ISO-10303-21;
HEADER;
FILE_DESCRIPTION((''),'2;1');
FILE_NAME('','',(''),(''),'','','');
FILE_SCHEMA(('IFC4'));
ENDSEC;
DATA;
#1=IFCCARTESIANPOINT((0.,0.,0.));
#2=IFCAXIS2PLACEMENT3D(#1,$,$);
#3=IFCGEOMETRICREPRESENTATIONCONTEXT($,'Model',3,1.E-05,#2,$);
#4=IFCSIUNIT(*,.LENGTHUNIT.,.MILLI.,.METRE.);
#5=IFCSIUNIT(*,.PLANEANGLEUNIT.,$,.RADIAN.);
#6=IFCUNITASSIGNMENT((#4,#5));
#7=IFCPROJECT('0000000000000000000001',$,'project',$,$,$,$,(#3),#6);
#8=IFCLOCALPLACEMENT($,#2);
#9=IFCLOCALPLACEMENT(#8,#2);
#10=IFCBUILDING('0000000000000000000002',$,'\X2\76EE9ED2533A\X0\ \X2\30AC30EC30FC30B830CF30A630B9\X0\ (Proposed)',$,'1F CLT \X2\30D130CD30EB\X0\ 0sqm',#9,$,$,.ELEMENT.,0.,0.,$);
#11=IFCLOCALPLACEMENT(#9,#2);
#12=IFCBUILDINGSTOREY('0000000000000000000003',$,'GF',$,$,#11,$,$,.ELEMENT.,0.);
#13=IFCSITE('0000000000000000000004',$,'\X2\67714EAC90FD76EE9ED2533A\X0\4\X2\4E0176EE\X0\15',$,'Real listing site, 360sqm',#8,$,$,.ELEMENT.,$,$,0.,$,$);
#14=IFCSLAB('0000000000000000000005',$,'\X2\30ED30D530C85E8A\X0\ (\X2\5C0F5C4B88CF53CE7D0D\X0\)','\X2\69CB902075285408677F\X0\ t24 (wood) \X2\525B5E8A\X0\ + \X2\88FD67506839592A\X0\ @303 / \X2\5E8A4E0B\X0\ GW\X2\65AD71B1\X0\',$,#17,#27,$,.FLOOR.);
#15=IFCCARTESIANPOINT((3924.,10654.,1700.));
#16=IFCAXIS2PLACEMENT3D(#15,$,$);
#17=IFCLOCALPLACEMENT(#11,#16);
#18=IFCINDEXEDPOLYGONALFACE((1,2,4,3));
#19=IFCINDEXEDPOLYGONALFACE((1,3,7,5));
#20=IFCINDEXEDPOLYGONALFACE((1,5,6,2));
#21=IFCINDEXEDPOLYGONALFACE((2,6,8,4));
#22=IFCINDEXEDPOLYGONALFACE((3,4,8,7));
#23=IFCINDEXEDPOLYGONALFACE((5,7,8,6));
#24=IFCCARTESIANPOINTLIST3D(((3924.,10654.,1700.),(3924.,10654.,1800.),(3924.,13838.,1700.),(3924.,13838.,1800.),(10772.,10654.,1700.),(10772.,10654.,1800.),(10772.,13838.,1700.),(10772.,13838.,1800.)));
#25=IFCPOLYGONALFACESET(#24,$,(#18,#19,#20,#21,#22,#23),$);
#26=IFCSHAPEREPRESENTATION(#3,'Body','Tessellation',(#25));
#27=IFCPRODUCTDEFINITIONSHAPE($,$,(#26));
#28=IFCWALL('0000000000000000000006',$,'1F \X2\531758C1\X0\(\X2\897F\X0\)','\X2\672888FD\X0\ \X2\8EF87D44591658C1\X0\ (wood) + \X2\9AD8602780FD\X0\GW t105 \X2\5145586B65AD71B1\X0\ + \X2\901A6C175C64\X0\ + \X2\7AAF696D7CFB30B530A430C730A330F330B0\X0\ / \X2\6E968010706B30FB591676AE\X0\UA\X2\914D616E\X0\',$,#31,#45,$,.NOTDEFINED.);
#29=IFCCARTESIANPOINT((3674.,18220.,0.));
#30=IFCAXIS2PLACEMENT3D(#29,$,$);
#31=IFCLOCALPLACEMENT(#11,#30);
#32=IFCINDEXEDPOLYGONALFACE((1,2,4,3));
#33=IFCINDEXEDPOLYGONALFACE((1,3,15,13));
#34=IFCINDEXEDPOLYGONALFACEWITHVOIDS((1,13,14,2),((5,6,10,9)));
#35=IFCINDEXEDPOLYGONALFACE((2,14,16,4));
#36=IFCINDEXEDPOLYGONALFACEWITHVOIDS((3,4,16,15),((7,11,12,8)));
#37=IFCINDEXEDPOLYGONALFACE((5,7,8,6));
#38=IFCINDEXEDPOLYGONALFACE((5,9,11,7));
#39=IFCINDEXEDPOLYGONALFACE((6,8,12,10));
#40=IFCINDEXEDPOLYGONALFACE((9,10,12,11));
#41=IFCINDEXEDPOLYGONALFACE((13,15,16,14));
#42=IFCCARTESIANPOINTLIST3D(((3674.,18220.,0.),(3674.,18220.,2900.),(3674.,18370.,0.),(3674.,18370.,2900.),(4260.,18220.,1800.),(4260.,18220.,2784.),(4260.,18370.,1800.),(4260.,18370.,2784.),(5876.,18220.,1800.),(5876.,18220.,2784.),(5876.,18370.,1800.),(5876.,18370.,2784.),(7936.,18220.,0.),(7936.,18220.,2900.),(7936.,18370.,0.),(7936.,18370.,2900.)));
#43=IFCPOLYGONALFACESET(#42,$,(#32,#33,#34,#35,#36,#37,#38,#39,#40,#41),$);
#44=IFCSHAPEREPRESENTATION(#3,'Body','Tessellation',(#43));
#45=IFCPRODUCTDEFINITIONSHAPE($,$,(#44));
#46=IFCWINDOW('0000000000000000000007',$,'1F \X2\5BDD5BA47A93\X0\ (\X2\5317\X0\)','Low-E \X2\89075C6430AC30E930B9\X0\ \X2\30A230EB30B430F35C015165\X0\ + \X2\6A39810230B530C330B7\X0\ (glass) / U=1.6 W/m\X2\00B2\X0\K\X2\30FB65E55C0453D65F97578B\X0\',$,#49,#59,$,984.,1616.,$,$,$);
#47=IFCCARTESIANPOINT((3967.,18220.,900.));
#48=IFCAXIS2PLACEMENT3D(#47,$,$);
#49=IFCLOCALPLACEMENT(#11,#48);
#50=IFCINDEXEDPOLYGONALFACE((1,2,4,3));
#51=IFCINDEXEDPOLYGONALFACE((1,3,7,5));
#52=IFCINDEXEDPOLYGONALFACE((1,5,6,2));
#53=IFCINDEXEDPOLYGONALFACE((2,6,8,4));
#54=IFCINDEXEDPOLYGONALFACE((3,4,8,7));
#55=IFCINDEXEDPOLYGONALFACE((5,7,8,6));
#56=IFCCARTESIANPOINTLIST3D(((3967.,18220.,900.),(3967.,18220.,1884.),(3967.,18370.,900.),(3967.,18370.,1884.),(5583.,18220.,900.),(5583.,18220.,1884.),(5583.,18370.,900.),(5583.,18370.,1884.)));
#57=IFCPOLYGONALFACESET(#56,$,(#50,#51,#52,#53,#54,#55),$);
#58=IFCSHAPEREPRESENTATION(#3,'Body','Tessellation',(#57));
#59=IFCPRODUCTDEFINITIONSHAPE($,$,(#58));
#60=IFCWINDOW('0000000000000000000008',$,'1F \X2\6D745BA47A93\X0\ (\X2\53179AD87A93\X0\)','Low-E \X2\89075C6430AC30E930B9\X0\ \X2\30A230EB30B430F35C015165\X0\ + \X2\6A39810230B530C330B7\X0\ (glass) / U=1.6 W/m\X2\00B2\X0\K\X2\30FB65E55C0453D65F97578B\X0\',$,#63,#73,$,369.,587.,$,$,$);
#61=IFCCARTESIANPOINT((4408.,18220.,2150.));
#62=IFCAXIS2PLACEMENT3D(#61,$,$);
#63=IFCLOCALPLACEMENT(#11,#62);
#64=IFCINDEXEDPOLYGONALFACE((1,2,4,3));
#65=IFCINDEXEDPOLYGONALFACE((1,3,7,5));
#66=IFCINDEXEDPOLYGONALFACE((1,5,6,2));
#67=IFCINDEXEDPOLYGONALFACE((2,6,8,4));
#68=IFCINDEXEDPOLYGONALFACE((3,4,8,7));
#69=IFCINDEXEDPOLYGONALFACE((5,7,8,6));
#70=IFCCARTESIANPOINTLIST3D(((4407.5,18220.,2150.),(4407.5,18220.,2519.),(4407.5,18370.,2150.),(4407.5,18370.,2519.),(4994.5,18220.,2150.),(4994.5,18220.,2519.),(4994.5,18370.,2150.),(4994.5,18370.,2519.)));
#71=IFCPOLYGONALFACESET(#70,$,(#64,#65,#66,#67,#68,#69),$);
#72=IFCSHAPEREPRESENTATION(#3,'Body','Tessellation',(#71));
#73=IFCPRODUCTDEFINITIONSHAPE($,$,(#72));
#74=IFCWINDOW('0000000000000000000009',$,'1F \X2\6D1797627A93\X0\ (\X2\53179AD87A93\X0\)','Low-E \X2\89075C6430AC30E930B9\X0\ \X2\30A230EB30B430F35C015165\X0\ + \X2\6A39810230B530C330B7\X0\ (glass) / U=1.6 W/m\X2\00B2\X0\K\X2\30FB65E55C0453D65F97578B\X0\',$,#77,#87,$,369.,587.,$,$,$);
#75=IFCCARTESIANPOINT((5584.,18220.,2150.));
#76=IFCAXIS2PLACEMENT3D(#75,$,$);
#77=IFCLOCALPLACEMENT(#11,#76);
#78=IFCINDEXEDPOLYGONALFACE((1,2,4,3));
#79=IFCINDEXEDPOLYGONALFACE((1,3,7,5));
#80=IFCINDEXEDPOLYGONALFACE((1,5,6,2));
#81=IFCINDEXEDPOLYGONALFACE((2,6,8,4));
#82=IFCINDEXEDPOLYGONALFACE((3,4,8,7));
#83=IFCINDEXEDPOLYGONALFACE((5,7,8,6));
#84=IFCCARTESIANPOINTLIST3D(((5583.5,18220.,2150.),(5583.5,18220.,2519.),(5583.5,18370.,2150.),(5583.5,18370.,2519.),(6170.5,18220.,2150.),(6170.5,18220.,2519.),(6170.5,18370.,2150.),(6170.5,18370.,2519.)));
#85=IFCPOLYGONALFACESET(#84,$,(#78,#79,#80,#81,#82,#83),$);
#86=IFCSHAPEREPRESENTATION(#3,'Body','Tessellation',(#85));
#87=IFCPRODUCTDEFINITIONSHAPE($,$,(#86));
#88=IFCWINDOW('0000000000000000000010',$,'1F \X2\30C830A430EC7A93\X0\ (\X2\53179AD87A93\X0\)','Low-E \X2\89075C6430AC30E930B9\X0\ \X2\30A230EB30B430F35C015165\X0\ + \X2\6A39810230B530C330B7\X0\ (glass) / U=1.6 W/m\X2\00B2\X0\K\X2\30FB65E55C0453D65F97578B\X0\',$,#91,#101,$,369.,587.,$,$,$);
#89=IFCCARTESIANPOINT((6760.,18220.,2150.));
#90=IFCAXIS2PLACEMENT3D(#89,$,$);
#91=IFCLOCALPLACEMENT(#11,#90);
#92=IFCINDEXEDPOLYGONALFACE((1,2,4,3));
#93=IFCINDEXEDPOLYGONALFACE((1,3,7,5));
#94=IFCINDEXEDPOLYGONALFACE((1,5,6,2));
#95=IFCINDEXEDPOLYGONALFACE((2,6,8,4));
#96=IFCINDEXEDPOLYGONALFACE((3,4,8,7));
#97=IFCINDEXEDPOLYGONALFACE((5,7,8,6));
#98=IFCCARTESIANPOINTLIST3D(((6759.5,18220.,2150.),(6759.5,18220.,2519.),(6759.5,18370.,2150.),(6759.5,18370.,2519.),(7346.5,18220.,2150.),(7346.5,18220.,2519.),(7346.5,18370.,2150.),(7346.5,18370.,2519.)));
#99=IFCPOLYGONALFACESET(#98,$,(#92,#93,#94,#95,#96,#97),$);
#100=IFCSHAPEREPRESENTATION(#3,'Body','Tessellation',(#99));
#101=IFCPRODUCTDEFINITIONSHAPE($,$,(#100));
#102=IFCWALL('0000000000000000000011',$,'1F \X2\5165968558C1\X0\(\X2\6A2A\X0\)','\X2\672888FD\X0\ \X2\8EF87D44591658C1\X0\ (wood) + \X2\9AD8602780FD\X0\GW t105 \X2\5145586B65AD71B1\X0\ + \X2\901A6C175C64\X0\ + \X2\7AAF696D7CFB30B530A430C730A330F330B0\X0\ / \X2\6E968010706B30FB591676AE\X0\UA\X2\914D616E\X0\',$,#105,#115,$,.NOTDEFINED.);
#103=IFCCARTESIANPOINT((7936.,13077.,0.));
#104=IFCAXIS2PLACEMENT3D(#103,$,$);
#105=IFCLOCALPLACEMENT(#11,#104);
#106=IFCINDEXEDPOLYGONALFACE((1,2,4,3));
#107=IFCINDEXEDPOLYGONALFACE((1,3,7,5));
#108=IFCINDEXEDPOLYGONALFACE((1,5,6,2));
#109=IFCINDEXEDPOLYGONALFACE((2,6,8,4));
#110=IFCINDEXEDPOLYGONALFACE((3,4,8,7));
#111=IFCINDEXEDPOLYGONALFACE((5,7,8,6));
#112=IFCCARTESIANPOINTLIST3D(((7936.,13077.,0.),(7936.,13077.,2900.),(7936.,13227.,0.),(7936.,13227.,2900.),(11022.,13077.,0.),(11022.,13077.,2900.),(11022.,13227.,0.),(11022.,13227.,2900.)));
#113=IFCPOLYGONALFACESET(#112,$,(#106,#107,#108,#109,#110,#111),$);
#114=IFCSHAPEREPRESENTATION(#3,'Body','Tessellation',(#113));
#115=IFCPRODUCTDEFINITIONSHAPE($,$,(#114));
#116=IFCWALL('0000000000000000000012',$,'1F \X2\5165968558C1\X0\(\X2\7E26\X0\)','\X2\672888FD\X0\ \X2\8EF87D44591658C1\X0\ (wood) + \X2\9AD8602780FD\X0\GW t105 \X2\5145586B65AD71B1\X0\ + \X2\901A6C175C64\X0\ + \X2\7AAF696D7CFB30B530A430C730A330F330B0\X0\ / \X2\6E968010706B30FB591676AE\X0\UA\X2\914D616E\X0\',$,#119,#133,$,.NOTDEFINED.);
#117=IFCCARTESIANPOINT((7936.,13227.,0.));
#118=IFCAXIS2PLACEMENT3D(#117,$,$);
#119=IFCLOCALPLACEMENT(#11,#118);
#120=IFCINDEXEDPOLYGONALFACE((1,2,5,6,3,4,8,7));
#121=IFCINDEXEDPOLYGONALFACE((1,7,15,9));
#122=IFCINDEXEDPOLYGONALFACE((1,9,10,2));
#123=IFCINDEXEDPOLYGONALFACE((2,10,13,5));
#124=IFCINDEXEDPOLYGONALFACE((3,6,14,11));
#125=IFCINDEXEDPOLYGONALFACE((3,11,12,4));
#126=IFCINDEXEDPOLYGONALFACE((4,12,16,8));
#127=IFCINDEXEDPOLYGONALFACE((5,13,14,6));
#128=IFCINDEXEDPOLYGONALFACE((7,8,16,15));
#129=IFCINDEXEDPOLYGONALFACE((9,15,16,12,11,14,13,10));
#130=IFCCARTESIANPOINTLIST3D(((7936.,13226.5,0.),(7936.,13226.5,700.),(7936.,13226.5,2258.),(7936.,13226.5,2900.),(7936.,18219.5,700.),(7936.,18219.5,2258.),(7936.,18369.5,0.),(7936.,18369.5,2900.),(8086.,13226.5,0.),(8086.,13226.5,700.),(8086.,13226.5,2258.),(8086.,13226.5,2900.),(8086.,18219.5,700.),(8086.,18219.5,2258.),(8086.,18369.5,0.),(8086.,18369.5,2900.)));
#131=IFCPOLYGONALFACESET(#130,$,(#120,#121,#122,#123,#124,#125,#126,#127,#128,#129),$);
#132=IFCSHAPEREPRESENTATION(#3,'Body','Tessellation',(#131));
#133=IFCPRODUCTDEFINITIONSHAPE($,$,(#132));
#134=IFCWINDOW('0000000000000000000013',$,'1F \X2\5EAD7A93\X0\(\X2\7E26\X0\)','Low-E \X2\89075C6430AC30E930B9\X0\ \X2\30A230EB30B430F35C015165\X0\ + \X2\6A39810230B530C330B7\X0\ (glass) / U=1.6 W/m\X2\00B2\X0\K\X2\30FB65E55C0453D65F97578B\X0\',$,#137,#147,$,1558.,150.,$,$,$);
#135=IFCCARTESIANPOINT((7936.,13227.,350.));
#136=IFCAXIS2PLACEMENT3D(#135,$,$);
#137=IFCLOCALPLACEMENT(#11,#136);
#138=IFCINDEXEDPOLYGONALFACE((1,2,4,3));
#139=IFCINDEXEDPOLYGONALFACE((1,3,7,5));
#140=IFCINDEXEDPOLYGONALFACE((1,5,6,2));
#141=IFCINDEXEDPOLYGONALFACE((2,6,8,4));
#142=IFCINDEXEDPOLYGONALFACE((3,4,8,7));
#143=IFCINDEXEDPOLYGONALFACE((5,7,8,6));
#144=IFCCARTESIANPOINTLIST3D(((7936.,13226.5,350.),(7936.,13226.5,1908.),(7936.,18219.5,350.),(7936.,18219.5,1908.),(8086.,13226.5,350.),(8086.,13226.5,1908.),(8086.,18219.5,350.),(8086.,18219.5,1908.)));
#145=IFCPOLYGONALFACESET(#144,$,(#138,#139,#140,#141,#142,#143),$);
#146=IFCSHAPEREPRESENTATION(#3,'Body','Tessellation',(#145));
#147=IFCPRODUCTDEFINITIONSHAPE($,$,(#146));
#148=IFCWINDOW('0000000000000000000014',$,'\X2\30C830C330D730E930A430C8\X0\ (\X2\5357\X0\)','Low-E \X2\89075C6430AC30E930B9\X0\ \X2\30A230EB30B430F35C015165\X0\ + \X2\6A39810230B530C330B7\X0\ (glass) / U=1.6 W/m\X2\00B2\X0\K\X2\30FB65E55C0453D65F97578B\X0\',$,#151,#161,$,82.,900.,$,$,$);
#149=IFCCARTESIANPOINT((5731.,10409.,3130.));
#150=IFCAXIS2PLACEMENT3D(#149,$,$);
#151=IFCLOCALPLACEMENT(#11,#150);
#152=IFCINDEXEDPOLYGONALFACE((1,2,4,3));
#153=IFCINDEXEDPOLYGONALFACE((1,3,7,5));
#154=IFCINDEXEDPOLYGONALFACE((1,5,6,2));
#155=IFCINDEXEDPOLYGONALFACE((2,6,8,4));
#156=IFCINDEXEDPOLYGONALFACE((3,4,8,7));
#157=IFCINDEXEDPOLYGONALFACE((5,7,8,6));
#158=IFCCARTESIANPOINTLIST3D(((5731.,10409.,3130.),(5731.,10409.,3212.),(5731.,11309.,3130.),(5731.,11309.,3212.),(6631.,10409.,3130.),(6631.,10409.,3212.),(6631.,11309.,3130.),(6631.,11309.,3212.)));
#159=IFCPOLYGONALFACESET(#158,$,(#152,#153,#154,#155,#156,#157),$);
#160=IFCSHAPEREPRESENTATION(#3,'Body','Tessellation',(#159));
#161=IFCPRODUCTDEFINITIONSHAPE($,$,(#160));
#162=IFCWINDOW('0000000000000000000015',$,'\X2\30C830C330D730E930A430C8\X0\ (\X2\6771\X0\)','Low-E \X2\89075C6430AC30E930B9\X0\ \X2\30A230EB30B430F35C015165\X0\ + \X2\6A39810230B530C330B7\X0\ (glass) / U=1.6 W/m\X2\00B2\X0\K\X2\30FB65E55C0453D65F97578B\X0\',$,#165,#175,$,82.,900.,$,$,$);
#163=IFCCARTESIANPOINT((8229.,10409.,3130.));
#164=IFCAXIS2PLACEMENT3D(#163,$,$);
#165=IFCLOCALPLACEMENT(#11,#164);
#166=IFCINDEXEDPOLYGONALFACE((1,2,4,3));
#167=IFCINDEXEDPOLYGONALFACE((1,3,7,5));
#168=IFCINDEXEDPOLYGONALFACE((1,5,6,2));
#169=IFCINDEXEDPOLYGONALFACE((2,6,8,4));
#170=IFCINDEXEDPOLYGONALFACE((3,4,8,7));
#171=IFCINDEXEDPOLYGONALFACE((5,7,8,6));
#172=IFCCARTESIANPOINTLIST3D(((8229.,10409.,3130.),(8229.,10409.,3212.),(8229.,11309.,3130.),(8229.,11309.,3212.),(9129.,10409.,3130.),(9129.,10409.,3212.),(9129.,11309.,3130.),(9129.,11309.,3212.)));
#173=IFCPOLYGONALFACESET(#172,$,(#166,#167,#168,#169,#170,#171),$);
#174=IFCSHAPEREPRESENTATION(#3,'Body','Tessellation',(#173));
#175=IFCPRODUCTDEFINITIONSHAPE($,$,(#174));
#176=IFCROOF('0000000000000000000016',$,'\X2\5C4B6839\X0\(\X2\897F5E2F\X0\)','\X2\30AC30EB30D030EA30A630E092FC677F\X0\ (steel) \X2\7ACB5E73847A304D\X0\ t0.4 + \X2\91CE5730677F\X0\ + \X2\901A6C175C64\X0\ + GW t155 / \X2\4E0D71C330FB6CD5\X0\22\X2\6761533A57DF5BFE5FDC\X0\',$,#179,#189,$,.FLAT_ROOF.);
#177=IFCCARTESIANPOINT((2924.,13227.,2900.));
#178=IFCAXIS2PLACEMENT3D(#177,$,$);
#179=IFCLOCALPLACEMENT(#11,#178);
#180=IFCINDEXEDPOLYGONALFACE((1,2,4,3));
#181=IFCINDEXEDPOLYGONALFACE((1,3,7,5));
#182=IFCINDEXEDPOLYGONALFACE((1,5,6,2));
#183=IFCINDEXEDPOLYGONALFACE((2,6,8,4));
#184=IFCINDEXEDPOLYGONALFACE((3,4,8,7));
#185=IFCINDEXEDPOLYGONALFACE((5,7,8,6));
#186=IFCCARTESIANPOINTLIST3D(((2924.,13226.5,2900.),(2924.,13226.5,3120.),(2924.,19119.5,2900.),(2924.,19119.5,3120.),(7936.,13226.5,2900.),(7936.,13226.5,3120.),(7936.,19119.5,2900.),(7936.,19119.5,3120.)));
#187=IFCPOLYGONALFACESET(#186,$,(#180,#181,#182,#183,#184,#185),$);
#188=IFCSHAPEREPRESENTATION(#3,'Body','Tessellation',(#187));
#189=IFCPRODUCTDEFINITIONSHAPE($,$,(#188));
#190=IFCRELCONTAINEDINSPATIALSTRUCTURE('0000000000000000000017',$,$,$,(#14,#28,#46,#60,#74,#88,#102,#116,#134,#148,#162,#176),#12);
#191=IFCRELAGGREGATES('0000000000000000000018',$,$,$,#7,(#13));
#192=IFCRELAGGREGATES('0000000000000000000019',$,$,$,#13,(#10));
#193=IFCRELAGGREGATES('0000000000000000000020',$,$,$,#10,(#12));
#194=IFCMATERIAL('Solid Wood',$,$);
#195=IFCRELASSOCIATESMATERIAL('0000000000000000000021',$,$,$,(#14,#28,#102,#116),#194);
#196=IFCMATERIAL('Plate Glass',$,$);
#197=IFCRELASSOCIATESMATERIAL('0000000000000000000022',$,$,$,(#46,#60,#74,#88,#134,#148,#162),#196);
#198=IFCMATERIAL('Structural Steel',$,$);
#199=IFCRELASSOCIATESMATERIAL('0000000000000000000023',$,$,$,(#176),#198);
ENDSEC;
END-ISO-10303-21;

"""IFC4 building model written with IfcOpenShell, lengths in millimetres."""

from ifc_helpers import new_model, si_unit, frame, frame_2d, origin, place, context, project, spatial, rectangle, extrude, material, element, fill, save


model = new_model("IFC4")

# Units and contexts
model_context = context("Model", 3, precision=1e-05, world=origin())
ifc_project = project(units=[si_unit("LENGTHUNIT", "METRE", prefix="MILLI"), si_unit("PLANEANGLEUNIT", "RADIAN")], contexts=[model_context])

# Site, building, storey
site_placement = place(None, origin())
site = spatial("IfcSite", under=ifc_project, at=site_placement, Name="東京都目黒区4丁目15", ObjectType="Real listing site, 360sqm", CompositionType="ELEMENT", RefElevation=0.0)
building_placement = place(site_placement, origin())
building = spatial("IfcBuilding", under=site, at=building_placement, Name="目黒区 ガレージハウス (Proposed)", ObjectType="1F CLT パネル 0sqm", CompositionType="ELEMENT", ElevationOfRefHeight=0.0, ElevationOfTerrain=0.0)
storey_placement = place(building_placement, origin())
storey = spatial("IfcBuildingStorey", under=building, at=storey_placement, Name="GF", CompositionType="ELEMENT", Elevation=0.0)

# Slab
ifc_material_1 = material(Name="Solid Wood")
slab_1_placement = place(storey_placement, frame((3924.0, 10654.0, 1700.0)))
element("IfcSlab", 1, at=slab_1_placement, inside=storey, material=ifc_material_1, Name="ロフト床 (小屋裏収納)", Description="構造用合板 t24 (wood) 剛床 + 製材根太 @303 / 床下 GW断熱", PredefinedType="FLOOR", context=model_context, shape_type="SweptSolid", body=[
    extrude(rectangle(XDim=6848.0, YDim=3184.0, at=frame_2d((3424.0, 1592.0))), frame((3924.0, 10654.0, 1700.0)), (0.0, 0.0, 1.0), 100.0),
])

# Wall, openings, windows
wall_1_placement = place(storey_placement, frame((3674.0, 18220.0, 0.0)))
wall_1 = element("IfcWall", 2, at=wall_1_placement, inside=storey, material=ifc_material_1, Name="1F 北壁(西)", Description="木製 軸組外壁 (wood) + 高性能GW t105 充填断熱 + 通気層 + 窯業系サイディング / 準耐火・外皮UA配慮", PredefinedType="NOTDEFINED", context=model_context, shape_type="SweptSolid", body=[
    extrude(rectangle(XDim=4262.0, YDim=150.0, at=frame_2d((2131.0, 75.0))), frame((3674.0, 18220.0, 0.0)), (0.0, 0.0, 1.0), 2900.0),
])
opening_1_placement = place(storey_placement, frame((3967.0, 18220.0, 900.0)))
opening_1 = element("IfcOpeningElement", 3, at=opening_1_placement, cuts=wall_1, PredefinedType="NOTDEFINED", context=model_context, shape_type="SweptSolid", body=[
    extrude(rectangle(XDim=1616.0, YDim=150.0, at=frame_2d((808.0, 75.0))), frame((3967.0, 18220.0, 900.0)), (0.0, 0.0, 1.0), 984.0),
])
opening_2_placement = place(storey_placement, frame((4408.0, 18220.0, 2150.0)))
opening_2 = element("IfcOpeningElement", 4, at=opening_2_placement, cuts=wall_1, PredefinedType="NOTDEFINED", context=model_context, shape_type="SweptSolid", body=[
    extrude(rectangle(XDim=587.0, YDim=150.0, at=frame_2d((293.0, 75.0))), frame((4408.0, 18220.0, 2150.0)), (0.0, 0.0, 1.0), 369.0),
])
opening_3_placement = place(storey_placement, frame((5584.0, 18220.0, 2150.0)))
opening_3 = element("IfcOpeningElement", 5, at=opening_3_placement, cuts=wall_1, PredefinedType="NOTDEFINED", context=model_context, shape_type="SweptSolid", body=[
    extrude(rectangle(XDim=587.0, YDim=150.0, at=frame_2d((293.0, 75.0))), frame((5584.0, 18220.0, 2150.0)), (0.0, 0.0, 1.0), 369.0),
])
opening_4_placement = place(storey_placement, frame((6760.0, 18220.0, 2150.0)))
opening_4 = element("IfcOpeningElement", 6, at=opening_4_placement, cuts=wall_1, PredefinedType="NOTDEFINED", context=model_context, shape_type="SweptSolid", body=[
    extrude(rectangle(XDim=587.0, YDim=150.0, at=frame_2d((293.0, 75.0))), frame((6760.0, 18220.0, 2150.0)), (0.0, 0.0, 1.0), 369.0),
])
ifc_material_2 = material(Name="Plate Glass")
window_1_placement = place(storey_placement, frame((3967.0, 18220.0, 900.0)))
window_1 = element("IfcWindow", 7, at=window_1_placement, inside=storey, material=ifc_material_2, Name="1F 寝室窓 (北)", Description="Low-E 複層ガラス アルゴン封入 + 樹脂サッシ (glass) / U=1.6 W/m²K・日射取得型", OverallHeight=984.0, OverallWidth=1616.0, context=model_context, shape_type="SweptSolid", body=[
    extrude(rectangle(XDim=1616.0, YDim=150.0, at=frame_2d((808.0, 75.0))), frame((3967.0, 18220.0, 900.0)), (0.0, 0.0, 1.0), 984.0),
])
fill(opening_1, window_1)
window_2_placement = place(storey_placement, frame((4408.0, 18220.0, 2150.0)))
window_2 = element("IfcWindow", 8, at=window_2_placement, inside=storey, material=ifc_material_2, Name="1F 浴室窓 (北高窓)", Description="Low-E 複層ガラス アルゴン封入 + 樹脂サッシ (glass) / U=1.6 W/m²K・日射取得型", OverallHeight=369.0, OverallWidth=587.0, context=model_context, shape_type="SweptSolid", body=[
    extrude(rectangle(XDim=587.0, YDim=150.0, at=frame_2d((293.0, 75.0))), frame((4408.0, 18220.0, 2150.0)), (0.0, 0.0, 1.0), 369.0),
])
fill(opening_2, window_2)
window_3_placement = place(storey_placement, frame((5584.0, 18220.0, 2150.0)))
window_3 = element("IfcWindow", 9, at=window_3_placement, inside=storey, material=ifc_material_2, Name="1F 洗面窓 (北高窓)", Description="Low-E 複層ガラス アルゴン封入 + 樹脂サッシ (glass) / U=1.6 W/m²K・日射取得型", OverallHeight=369.0, OverallWidth=587.0, context=model_context, shape_type="SweptSolid", body=[
    extrude(rectangle(XDim=587.0, YDim=150.0, at=frame_2d((293.0, 75.0))), frame((5584.0, 18220.0, 2150.0)), (0.0, 0.0, 1.0), 369.0),
])
fill(opening_3, window_3)
window_4_placement = place(storey_placement, frame((6760.0, 18220.0, 2150.0)))
window_4 = element("IfcWindow", 10, at=window_4_placement, inside=storey, material=ifc_material_2, Name="1F トイレ窓 (北高窓)", Description="Low-E 複層ガラス アルゴン封入 + 樹脂サッシ (glass) / U=1.6 W/m²K・日射取得型", OverallHeight=369.0, OverallWidth=587.0, context=model_context, shape_type="SweptSolid", body=[
    extrude(rectangle(XDim=587.0, YDim=150.0, at=frame_2d((293.0, 75.0))), frame((6760.0, 18220.0, 2150.0)), (0.0, 0.0, 1.0), 369.0),
])
fill(opening_4, window_4)

# Wall
wall_2_placement = place(storey_placement, frame((7936.0, 13077.0, 0.0)))
element("IfcWall", 11, at=wall_2_placement, inside=storey, material=ifc_material_1, Name="1F 入隅壁(横)", Description="木製 軸組外壁 (wood) + 高性能GW t105 充填断熱 + 通気層 + 窯業系サイディング / 準耐火・外皮UA配慮", PredefinedType="NOTDEFINED", context=model_context, shape_type="SweptSolid", body=[
    extrude(rectangle(XDim=3086.0, YDim=150.0, at=frame_2d((1543.0, 75.0))), frame((7936.0, 13077.0, 0.0)), (0.0, 0.0, 1.0), 2900.0),
])

# Wall, opening, window
wall_3_placement = place(storey_placement, frame((7936.0, 13227.0, 0.0)))
wall_3 = element("IfcWall", 12, at=wall_3_placement, inside=storey, material=ifc_material_1, Name="1F 入隅壁(縦)", Description="木製 軸組外壁 (wood) + 高性能GW t105 充填断熱 + 通気層 + 窯業系サイディング / 準耐火・外皮UA配慮", PredefinedType="NOTDEFINED", context=model_context, shape_type="SweptSolid", body=[
    extrude(rectangle(XDim=150.0, YDim=5143.0, at=frame_2d((75.0, 2571.0))), frame((7936.0, 13227.0, 0.0)), (0.0, 0.0, 1.0), 2900.0),
])
opening_5_placement = place(storey_placement, frame((7936.0, 13227.0, 350.0)))
opening_5 = element("IfcOpeningElement", 13, at=opening_5_placement, cuts=wall_3, PredefinedType="NOTDEFINED", context=model_context, shape_type="SweptSolid", body=[
    extrude(rectangle(XDim=150.0, YDim=4993.0, at=frame_2d((75.0, 2496.0))), frame((7936.0, 13227.0, 350.0)), (0.0, 0.0, 1.0), 1558.0),
])
window_5_placement = place(storey_placement, frame((7936.0, 13227.0, 350.0)))
window_5 = element("IfcWindow", 14, at=window_5_placement, inside=storey, material=ifc_material_2, Name="1F 庭窓(縦)", Description="Low-E 複層ガラス アルゴン封入 + 樹脂サッシ (glass) / U=1.6 W/m²K・日射取得型", OverallHeight=1558.0, OverallWidth=150.0, context=model_context, shape_type="SweptSolid", body=[
    extrude(rectangle(XDim=150.0, YDim=4993.0, at=frame_2d((75.0, 2496.0))), frame((7936.0, 13227.0, 350.0)), (0.0, 0.0, 1.0), 1558.0),
])
fill(opening_5, window_5)

# Windows
window_6_placement = place(storey_placement, frame((5731.0, 10409.0, 3130.0)))
element("IfcWindow", 15, at=window_6_placement, inside=storey, material=ifc_material_2, Name="トップライト (南)", Description="Low-E 複層ガラス アルゴン封入 + 樹脂サッシ (glass) / U=1.6 W/m²K・日射取得型", OverallHeight=82.0, OverallWidth=900.0, context=model_context, shape_type="SweptSolid", body=[
    extrude(rectangle(XDim=900.0, YDim=900.0, at=frame_2d((450.0, 450.0))), frame((5731.0, 10409.0, 3130.0)), (0.0, 0.0, 1.0), 82.0),
])
window_7_placement = place(storey_placement, frame((8229.0, 10409.0, 3130.0)))
element("IfcWindow", 16, at=window_7_placement, inside=storey, material=ifc_material_2, Name="トップライト (東)", Description="Low-E 複層ガラス アルゴン封入 + 樹脂サッシ (glass) / U=1.6 W/m²K・日射取得型", OverallHeight=82.0, OverallWidth=900.0, context=model_context, shape_type="SweptSolid", body=[
    extrude(rectangle(XDim=900.0, YDim=900.0, at=frame_2d((450.0, 450.0))), frame((8229.0, 10409.0, 3130.0)), (0.0, 0.0, 1.0), 82.0),
])

# Roof
ifc_material_3 = material(Name="Structural Steel")
roof_placement = place(storey_placement, frame((2924.0, 13227.0, 2900.0)))
element("IfcRoof", 17, at=roof_placement, inside=storey, material=ifc_material_3, Name="屋根(西帯)", Description="ガルバリウム鋼板 (steel) 立平葺き t0.4 + 野地板 + 通気層 + GW t155 / 不燃・法22条区域対応", PredefinedType="FLAT_ROOF", context=model_context, shape_type="SweptSolid", body=[
    extrude(rectangle(XDim=5012.0, YDim=5893.0, at=frame_2d((2506.0, 2946.0))), frame((2924.0, 13227.0, 2900.0)), (0.0, 0.0, 1.0), 220.0),
])

save(model, "model.ifc")
